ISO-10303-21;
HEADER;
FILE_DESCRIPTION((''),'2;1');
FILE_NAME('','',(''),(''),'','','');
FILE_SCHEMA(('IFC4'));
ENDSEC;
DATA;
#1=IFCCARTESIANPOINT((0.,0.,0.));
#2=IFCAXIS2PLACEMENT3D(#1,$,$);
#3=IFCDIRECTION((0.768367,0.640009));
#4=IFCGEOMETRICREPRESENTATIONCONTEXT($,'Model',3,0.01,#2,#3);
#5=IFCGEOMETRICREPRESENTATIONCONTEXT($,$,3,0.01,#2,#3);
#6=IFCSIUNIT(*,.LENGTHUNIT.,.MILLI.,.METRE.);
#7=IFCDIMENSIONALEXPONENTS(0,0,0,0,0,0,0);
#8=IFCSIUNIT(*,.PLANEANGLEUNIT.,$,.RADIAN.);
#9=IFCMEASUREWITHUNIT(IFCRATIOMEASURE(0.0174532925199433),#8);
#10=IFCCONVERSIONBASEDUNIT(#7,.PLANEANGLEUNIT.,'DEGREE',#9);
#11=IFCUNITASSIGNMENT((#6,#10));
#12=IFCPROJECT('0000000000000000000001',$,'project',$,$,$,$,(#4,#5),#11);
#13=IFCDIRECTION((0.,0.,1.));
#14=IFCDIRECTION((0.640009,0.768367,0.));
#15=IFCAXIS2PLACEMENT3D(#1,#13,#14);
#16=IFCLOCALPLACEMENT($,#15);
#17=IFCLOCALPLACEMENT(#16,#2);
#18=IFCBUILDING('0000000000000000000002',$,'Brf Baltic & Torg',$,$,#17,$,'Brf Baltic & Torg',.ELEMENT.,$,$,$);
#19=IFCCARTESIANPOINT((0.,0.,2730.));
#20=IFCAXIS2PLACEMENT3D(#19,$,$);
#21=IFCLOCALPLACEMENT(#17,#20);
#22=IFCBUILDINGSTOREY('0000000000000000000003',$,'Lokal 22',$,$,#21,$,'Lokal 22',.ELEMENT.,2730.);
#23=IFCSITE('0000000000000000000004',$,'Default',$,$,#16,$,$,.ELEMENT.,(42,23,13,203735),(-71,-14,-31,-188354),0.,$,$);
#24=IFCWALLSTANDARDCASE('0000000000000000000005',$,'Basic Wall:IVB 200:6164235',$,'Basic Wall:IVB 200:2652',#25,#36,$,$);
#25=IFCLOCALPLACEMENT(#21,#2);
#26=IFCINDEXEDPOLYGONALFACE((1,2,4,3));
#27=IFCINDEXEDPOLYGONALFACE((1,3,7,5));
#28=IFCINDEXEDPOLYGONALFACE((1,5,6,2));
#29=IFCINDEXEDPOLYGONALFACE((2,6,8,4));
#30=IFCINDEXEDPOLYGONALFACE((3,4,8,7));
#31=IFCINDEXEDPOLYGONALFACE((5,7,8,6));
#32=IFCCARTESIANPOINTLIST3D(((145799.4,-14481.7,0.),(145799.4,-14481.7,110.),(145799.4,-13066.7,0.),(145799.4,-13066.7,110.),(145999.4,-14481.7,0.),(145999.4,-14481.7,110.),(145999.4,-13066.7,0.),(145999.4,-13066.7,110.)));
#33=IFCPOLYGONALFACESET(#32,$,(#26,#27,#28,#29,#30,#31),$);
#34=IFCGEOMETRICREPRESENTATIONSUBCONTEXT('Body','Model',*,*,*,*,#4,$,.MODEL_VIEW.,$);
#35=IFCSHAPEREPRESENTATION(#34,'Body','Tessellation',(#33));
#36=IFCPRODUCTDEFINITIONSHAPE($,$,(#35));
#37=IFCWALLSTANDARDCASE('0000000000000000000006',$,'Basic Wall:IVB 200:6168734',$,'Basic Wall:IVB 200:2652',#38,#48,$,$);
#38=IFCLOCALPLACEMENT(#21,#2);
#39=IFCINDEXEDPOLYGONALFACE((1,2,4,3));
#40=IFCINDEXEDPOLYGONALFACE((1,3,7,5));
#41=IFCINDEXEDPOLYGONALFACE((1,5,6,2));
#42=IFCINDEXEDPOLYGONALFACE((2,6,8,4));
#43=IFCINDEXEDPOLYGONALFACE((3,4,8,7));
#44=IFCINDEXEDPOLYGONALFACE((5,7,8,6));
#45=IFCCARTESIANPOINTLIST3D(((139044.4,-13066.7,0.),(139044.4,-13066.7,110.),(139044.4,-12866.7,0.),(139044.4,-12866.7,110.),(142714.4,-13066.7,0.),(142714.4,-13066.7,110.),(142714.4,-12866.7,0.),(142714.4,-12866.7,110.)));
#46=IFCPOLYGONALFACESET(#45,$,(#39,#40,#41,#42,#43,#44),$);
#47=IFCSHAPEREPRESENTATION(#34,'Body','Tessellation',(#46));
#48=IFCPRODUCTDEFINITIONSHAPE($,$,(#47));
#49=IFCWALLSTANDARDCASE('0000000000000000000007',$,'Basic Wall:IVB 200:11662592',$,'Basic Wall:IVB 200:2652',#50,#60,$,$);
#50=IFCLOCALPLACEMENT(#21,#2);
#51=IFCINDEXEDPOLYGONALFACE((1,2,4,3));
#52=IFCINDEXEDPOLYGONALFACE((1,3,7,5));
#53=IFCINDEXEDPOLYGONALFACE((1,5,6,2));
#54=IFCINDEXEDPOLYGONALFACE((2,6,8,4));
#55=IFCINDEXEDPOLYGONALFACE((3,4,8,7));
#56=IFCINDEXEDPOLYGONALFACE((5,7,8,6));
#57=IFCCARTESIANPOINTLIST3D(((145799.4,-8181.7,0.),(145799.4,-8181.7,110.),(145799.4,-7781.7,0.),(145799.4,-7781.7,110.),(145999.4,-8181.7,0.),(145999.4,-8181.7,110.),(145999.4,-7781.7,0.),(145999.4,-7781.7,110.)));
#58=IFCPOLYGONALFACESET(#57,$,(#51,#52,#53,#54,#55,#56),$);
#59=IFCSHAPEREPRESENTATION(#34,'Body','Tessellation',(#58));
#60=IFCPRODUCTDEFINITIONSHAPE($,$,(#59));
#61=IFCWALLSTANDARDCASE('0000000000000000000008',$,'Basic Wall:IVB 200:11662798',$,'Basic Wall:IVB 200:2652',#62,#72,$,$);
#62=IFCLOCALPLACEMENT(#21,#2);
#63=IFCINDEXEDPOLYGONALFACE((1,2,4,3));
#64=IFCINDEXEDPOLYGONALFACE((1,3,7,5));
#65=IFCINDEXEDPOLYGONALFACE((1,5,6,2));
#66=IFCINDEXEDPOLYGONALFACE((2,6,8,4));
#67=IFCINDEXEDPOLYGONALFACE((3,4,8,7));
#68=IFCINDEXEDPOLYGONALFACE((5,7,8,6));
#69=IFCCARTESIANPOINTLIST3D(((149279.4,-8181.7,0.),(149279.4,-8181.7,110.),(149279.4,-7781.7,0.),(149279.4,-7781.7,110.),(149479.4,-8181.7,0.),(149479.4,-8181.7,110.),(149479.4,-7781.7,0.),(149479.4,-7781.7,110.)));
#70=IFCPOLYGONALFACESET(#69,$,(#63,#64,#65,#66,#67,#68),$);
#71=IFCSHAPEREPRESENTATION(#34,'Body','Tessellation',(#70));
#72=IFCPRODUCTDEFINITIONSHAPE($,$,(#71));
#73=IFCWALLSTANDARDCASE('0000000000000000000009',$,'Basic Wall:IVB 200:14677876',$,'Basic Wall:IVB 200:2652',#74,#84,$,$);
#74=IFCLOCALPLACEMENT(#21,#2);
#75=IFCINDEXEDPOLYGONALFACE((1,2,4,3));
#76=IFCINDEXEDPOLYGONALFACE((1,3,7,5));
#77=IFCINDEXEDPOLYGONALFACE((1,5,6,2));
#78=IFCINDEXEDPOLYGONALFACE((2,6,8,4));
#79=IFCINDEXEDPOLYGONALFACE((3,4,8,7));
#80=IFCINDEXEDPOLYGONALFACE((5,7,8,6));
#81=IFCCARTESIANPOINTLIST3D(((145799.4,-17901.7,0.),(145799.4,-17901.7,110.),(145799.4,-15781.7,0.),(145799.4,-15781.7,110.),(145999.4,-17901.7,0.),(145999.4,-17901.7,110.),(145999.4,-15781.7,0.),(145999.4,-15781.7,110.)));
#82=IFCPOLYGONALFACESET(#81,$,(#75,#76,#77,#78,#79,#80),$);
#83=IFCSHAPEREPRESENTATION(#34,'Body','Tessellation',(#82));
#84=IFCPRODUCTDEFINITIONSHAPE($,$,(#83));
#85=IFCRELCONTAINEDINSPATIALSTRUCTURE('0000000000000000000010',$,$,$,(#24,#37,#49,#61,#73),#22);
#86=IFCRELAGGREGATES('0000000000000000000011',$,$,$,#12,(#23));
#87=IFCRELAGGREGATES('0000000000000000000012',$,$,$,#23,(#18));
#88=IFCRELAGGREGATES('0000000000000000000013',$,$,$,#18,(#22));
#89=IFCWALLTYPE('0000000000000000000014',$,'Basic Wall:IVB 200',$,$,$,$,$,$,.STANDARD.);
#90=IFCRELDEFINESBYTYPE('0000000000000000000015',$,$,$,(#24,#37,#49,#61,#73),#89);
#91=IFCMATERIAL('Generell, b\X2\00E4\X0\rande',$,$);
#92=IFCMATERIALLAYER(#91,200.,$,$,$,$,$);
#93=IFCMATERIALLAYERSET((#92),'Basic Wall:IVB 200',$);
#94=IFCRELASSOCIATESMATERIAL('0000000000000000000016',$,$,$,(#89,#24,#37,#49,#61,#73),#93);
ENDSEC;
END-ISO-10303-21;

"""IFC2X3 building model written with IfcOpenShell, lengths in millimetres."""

from ifc_helpers import new_model, entity, si_unit, converted_unit, direction, frame, frame_2d, origin, place, context, subcontext, project, spatial, rectangle, extrude, clip, halfspace, material, layer, layer_set, layer_usage, type_object, element, save


model = new_model("IFC2X3")

# Units and contexts
model_context = context("Model", 3, precision=0.01, world=origin(), true_north=direction((0.768367, 0.640009)))
context_of_model = context(None, 3, precision=0.01, world=origin(), true_north=direction((0.768367, 0.640009)))
body_context = subcontext(model_context, "Body", "Model", "MODEL_VIEW")
ifc_project = project(units=[si_unit("LENGTHUNIT", "METRE", prefix="MILLI"), converted_unit("PLANEANGLEUNIT", "DEGREE", entity("IfcRatioMeasure", 0.0174532925199433), si_unit("PLANEANGLEUNIT", "RADIAN"), dimensions=[0, 0, 0, 0, 0, 0, 0])], contexts=[model_context, context_of_model])

# Site, building, storey
site_placement = place(None, frame((0.0, 0.0, 0.0), z_axis=(0.0, 0.0, 1.0), x_axis=(0.640009, 0.768367, 0.0)))
site = spatial("IfcSite", under=ifc_project, at=site_placement, Name="Default", CompositionType="ELEMENT", RefLatitude=(42, 23, 13, 203735), RefLongitude=(-71, -14, -31, -188354), RefElevation=0.0)
building_placement = place(site_placement, origin())
building = spatial("IfcBuilding", under=site, at=building_placement, Name="Brf Baltic & Torg", LongName="Brf Baltic & Torg", CompositionType="ELEMENT")
storey_placement = place(building_placement, frame((0.0, 0.0, 2730.0)))
storey = spatial("IfcBuildingStorey", under=building, at=storey_placement, Name="Lokal 22", LongName="Lokal 22", CompositionType="ELEMENT", Elevation=2730.0)

# Wall
ifc_material_1 = material(Name="Generell, bärande")
ifc_layer_1 = layer(ifc_material_1, 200.0)
ifc_layer_set_1 = layer_set([ifc_layer_1], Name="Basic Wall:IVB 200")
wall_type_1 = type_object("IfcWallType", Name="Basic Wall:IVB 200", PredefinedType="STANDARD", material=ifc_layer_set_1)
ifc_layer_usage_1 = layer_usage(ifc_layer_set_1, "AXIS2", "POSITIVE", -100.0)
wall_1_placement = place(storey_placement, frame((145899.4, -13066.7, 0.0), z_axis=(0.0, 0.0, 1.0), x_axis=(0.0, -1.0, 0.0)))
element("IfcWallStandardCase", 1, at=wall_1_placement, inside=storey, type_object=wall_type_1, material=ifc_layer_usage_1, Name="Basic Wall:IVB 200:6164235", ObjectType="Basic Wall:IVB 200:2652", context=body_context, shape_type="Clipping", body=[
    clip(extrude(rectangle(XDim=1415.0, YDim=200.0, at=frame_2d((707.5, 0.0), x_axis=(-1.0, 0.0))), origin(), (0.0, 0.0, 1.0), 110.0), halfspace(frame((0.0, 0.0, -1080.0)), True)),
])

# Wall
ifc_layer_usage_2 = layer_usage(ifc_layer_set_1, "AXIS2", "NEGATIVE", 100.0)
wall_2_placement = place(storey_placement, frame((142714.4, -12966.7, 0.0), z_axis=(0.0, 0.0, 1.0), x_axis=(-1.0, 0.0, 0.0)))
element("IfcWallStandardCase", 2, at=wall_2_placement, inside=storey, type_object=wall_type_1, material=ifc_layer_usage_2, Name="Basic Wall:IVB 200:6168734", ObjectType="Basic Wall:IVB 200:2652", context=body_context, shape_type="Clipping", body=[
    clip(extrude(rectangle(XDim=3670.0, YDim=200.0, at=frame_2d((1835.0, 0.0), x_axis=(-1.0, 0.0))), origin(), (0.0, 0.0, 1.0), 110.0), halfspace(frame((0.0, 0.0, -1080.0)), True)),
])

# Walls
ifc_layer_usage_3 = layer_usage(ifc_layer_set_1, "AXIS2", "POSITIVE", -100.0)
wall_3_placement = place(storey_placement, frame((145899.4, -7781.7, 0.0), z_axis=(0.0, 0.0, 1.0), x_axis=(0.0, -1.0, 0.0)))
element("IfcWallStandardCase", 3, at=wall_3_placement, inside=storey, type_object=wall_type_1, material=ifc_layer_usage_3, Name="Basic Wall:IVB 200:11662592", ObjectType="Basic Wall:IVB 200:2652", context=body_context, shape_type="Clipping", body=[
    clip(extrude(rectangle(XDim=400.0, YDim=200.0, at=frame_2d((200.0, 0.0), x_axis=(-1.0, 0.0))), origin(), (0.0, 0.0, 1.0), 110.0), halfspace(frame((0.0, 0.0, -1080.0)), True)),
])
ifc_layer_usage_4 = layer_usage(ifc_layer_set_1, "AXIS2", "NEGATIVE", 100.0)
wall_4_placement = place(storey_placement, frame((149379.4, -8181.7, 0.0), z_axis=(0.0, 0.0, 1.0), x_axis=(0.0, 1.0, 0.0)))
element("IfcWallStandardCase", 4, at=wall_4_placement, inside=storey, type_object=wall_type_1, material=ifc_layer_usage_4, Name="Basic Wall:IVB 200:11662798", ObjectType="Basic Wall:IVB 200:2652", context=body_context, shape_type="Clipping", body=[
    clip(extrude(rectangle(XDim=400.0, YDim=200.0, at=frame_2d((200.0, 0.0), x_axis=(-1.0, 0.0))), origin(), (0.0, 0.0, 1.0), 110.0), halfspace(frame((0.0, 0.0, -1080.0)), True)),
])
ifc_layer_usage_5 = layer_usage(ifc_layer_set_1, "AXIS2", "POSITIVE", -100.0)
wall_5_placement = place(storey_placement, frame((145899.4, -15781.7, 0.0), z_axis=(0.0, 0.0, 1.0), x_axis=(0.0, -1.0, 0.0)))
element("IfcWallStandardCase", 5, at=wall_5_placement, inside=storey, type_object=wall_type_1, material=ifc_layer_usage_5, Name="Basic Wall:IVB 200:14677876", ObjectType="Basic Wall:IVB 200:2652", context=body_context, shape_type="Clipping", body=[
    clip(extrude(rectangle(XDim=2120.0, YDim=200.0, at=frame_2d((1060.0, 0.0), x_axis=(-1.0, 0.0))), origin(), (0.0, 0.0, 1.0), 110.0), halfspace(frame((0.0, 0.0, -1080.0)), True)),
])

save(model, "model.ifc")
